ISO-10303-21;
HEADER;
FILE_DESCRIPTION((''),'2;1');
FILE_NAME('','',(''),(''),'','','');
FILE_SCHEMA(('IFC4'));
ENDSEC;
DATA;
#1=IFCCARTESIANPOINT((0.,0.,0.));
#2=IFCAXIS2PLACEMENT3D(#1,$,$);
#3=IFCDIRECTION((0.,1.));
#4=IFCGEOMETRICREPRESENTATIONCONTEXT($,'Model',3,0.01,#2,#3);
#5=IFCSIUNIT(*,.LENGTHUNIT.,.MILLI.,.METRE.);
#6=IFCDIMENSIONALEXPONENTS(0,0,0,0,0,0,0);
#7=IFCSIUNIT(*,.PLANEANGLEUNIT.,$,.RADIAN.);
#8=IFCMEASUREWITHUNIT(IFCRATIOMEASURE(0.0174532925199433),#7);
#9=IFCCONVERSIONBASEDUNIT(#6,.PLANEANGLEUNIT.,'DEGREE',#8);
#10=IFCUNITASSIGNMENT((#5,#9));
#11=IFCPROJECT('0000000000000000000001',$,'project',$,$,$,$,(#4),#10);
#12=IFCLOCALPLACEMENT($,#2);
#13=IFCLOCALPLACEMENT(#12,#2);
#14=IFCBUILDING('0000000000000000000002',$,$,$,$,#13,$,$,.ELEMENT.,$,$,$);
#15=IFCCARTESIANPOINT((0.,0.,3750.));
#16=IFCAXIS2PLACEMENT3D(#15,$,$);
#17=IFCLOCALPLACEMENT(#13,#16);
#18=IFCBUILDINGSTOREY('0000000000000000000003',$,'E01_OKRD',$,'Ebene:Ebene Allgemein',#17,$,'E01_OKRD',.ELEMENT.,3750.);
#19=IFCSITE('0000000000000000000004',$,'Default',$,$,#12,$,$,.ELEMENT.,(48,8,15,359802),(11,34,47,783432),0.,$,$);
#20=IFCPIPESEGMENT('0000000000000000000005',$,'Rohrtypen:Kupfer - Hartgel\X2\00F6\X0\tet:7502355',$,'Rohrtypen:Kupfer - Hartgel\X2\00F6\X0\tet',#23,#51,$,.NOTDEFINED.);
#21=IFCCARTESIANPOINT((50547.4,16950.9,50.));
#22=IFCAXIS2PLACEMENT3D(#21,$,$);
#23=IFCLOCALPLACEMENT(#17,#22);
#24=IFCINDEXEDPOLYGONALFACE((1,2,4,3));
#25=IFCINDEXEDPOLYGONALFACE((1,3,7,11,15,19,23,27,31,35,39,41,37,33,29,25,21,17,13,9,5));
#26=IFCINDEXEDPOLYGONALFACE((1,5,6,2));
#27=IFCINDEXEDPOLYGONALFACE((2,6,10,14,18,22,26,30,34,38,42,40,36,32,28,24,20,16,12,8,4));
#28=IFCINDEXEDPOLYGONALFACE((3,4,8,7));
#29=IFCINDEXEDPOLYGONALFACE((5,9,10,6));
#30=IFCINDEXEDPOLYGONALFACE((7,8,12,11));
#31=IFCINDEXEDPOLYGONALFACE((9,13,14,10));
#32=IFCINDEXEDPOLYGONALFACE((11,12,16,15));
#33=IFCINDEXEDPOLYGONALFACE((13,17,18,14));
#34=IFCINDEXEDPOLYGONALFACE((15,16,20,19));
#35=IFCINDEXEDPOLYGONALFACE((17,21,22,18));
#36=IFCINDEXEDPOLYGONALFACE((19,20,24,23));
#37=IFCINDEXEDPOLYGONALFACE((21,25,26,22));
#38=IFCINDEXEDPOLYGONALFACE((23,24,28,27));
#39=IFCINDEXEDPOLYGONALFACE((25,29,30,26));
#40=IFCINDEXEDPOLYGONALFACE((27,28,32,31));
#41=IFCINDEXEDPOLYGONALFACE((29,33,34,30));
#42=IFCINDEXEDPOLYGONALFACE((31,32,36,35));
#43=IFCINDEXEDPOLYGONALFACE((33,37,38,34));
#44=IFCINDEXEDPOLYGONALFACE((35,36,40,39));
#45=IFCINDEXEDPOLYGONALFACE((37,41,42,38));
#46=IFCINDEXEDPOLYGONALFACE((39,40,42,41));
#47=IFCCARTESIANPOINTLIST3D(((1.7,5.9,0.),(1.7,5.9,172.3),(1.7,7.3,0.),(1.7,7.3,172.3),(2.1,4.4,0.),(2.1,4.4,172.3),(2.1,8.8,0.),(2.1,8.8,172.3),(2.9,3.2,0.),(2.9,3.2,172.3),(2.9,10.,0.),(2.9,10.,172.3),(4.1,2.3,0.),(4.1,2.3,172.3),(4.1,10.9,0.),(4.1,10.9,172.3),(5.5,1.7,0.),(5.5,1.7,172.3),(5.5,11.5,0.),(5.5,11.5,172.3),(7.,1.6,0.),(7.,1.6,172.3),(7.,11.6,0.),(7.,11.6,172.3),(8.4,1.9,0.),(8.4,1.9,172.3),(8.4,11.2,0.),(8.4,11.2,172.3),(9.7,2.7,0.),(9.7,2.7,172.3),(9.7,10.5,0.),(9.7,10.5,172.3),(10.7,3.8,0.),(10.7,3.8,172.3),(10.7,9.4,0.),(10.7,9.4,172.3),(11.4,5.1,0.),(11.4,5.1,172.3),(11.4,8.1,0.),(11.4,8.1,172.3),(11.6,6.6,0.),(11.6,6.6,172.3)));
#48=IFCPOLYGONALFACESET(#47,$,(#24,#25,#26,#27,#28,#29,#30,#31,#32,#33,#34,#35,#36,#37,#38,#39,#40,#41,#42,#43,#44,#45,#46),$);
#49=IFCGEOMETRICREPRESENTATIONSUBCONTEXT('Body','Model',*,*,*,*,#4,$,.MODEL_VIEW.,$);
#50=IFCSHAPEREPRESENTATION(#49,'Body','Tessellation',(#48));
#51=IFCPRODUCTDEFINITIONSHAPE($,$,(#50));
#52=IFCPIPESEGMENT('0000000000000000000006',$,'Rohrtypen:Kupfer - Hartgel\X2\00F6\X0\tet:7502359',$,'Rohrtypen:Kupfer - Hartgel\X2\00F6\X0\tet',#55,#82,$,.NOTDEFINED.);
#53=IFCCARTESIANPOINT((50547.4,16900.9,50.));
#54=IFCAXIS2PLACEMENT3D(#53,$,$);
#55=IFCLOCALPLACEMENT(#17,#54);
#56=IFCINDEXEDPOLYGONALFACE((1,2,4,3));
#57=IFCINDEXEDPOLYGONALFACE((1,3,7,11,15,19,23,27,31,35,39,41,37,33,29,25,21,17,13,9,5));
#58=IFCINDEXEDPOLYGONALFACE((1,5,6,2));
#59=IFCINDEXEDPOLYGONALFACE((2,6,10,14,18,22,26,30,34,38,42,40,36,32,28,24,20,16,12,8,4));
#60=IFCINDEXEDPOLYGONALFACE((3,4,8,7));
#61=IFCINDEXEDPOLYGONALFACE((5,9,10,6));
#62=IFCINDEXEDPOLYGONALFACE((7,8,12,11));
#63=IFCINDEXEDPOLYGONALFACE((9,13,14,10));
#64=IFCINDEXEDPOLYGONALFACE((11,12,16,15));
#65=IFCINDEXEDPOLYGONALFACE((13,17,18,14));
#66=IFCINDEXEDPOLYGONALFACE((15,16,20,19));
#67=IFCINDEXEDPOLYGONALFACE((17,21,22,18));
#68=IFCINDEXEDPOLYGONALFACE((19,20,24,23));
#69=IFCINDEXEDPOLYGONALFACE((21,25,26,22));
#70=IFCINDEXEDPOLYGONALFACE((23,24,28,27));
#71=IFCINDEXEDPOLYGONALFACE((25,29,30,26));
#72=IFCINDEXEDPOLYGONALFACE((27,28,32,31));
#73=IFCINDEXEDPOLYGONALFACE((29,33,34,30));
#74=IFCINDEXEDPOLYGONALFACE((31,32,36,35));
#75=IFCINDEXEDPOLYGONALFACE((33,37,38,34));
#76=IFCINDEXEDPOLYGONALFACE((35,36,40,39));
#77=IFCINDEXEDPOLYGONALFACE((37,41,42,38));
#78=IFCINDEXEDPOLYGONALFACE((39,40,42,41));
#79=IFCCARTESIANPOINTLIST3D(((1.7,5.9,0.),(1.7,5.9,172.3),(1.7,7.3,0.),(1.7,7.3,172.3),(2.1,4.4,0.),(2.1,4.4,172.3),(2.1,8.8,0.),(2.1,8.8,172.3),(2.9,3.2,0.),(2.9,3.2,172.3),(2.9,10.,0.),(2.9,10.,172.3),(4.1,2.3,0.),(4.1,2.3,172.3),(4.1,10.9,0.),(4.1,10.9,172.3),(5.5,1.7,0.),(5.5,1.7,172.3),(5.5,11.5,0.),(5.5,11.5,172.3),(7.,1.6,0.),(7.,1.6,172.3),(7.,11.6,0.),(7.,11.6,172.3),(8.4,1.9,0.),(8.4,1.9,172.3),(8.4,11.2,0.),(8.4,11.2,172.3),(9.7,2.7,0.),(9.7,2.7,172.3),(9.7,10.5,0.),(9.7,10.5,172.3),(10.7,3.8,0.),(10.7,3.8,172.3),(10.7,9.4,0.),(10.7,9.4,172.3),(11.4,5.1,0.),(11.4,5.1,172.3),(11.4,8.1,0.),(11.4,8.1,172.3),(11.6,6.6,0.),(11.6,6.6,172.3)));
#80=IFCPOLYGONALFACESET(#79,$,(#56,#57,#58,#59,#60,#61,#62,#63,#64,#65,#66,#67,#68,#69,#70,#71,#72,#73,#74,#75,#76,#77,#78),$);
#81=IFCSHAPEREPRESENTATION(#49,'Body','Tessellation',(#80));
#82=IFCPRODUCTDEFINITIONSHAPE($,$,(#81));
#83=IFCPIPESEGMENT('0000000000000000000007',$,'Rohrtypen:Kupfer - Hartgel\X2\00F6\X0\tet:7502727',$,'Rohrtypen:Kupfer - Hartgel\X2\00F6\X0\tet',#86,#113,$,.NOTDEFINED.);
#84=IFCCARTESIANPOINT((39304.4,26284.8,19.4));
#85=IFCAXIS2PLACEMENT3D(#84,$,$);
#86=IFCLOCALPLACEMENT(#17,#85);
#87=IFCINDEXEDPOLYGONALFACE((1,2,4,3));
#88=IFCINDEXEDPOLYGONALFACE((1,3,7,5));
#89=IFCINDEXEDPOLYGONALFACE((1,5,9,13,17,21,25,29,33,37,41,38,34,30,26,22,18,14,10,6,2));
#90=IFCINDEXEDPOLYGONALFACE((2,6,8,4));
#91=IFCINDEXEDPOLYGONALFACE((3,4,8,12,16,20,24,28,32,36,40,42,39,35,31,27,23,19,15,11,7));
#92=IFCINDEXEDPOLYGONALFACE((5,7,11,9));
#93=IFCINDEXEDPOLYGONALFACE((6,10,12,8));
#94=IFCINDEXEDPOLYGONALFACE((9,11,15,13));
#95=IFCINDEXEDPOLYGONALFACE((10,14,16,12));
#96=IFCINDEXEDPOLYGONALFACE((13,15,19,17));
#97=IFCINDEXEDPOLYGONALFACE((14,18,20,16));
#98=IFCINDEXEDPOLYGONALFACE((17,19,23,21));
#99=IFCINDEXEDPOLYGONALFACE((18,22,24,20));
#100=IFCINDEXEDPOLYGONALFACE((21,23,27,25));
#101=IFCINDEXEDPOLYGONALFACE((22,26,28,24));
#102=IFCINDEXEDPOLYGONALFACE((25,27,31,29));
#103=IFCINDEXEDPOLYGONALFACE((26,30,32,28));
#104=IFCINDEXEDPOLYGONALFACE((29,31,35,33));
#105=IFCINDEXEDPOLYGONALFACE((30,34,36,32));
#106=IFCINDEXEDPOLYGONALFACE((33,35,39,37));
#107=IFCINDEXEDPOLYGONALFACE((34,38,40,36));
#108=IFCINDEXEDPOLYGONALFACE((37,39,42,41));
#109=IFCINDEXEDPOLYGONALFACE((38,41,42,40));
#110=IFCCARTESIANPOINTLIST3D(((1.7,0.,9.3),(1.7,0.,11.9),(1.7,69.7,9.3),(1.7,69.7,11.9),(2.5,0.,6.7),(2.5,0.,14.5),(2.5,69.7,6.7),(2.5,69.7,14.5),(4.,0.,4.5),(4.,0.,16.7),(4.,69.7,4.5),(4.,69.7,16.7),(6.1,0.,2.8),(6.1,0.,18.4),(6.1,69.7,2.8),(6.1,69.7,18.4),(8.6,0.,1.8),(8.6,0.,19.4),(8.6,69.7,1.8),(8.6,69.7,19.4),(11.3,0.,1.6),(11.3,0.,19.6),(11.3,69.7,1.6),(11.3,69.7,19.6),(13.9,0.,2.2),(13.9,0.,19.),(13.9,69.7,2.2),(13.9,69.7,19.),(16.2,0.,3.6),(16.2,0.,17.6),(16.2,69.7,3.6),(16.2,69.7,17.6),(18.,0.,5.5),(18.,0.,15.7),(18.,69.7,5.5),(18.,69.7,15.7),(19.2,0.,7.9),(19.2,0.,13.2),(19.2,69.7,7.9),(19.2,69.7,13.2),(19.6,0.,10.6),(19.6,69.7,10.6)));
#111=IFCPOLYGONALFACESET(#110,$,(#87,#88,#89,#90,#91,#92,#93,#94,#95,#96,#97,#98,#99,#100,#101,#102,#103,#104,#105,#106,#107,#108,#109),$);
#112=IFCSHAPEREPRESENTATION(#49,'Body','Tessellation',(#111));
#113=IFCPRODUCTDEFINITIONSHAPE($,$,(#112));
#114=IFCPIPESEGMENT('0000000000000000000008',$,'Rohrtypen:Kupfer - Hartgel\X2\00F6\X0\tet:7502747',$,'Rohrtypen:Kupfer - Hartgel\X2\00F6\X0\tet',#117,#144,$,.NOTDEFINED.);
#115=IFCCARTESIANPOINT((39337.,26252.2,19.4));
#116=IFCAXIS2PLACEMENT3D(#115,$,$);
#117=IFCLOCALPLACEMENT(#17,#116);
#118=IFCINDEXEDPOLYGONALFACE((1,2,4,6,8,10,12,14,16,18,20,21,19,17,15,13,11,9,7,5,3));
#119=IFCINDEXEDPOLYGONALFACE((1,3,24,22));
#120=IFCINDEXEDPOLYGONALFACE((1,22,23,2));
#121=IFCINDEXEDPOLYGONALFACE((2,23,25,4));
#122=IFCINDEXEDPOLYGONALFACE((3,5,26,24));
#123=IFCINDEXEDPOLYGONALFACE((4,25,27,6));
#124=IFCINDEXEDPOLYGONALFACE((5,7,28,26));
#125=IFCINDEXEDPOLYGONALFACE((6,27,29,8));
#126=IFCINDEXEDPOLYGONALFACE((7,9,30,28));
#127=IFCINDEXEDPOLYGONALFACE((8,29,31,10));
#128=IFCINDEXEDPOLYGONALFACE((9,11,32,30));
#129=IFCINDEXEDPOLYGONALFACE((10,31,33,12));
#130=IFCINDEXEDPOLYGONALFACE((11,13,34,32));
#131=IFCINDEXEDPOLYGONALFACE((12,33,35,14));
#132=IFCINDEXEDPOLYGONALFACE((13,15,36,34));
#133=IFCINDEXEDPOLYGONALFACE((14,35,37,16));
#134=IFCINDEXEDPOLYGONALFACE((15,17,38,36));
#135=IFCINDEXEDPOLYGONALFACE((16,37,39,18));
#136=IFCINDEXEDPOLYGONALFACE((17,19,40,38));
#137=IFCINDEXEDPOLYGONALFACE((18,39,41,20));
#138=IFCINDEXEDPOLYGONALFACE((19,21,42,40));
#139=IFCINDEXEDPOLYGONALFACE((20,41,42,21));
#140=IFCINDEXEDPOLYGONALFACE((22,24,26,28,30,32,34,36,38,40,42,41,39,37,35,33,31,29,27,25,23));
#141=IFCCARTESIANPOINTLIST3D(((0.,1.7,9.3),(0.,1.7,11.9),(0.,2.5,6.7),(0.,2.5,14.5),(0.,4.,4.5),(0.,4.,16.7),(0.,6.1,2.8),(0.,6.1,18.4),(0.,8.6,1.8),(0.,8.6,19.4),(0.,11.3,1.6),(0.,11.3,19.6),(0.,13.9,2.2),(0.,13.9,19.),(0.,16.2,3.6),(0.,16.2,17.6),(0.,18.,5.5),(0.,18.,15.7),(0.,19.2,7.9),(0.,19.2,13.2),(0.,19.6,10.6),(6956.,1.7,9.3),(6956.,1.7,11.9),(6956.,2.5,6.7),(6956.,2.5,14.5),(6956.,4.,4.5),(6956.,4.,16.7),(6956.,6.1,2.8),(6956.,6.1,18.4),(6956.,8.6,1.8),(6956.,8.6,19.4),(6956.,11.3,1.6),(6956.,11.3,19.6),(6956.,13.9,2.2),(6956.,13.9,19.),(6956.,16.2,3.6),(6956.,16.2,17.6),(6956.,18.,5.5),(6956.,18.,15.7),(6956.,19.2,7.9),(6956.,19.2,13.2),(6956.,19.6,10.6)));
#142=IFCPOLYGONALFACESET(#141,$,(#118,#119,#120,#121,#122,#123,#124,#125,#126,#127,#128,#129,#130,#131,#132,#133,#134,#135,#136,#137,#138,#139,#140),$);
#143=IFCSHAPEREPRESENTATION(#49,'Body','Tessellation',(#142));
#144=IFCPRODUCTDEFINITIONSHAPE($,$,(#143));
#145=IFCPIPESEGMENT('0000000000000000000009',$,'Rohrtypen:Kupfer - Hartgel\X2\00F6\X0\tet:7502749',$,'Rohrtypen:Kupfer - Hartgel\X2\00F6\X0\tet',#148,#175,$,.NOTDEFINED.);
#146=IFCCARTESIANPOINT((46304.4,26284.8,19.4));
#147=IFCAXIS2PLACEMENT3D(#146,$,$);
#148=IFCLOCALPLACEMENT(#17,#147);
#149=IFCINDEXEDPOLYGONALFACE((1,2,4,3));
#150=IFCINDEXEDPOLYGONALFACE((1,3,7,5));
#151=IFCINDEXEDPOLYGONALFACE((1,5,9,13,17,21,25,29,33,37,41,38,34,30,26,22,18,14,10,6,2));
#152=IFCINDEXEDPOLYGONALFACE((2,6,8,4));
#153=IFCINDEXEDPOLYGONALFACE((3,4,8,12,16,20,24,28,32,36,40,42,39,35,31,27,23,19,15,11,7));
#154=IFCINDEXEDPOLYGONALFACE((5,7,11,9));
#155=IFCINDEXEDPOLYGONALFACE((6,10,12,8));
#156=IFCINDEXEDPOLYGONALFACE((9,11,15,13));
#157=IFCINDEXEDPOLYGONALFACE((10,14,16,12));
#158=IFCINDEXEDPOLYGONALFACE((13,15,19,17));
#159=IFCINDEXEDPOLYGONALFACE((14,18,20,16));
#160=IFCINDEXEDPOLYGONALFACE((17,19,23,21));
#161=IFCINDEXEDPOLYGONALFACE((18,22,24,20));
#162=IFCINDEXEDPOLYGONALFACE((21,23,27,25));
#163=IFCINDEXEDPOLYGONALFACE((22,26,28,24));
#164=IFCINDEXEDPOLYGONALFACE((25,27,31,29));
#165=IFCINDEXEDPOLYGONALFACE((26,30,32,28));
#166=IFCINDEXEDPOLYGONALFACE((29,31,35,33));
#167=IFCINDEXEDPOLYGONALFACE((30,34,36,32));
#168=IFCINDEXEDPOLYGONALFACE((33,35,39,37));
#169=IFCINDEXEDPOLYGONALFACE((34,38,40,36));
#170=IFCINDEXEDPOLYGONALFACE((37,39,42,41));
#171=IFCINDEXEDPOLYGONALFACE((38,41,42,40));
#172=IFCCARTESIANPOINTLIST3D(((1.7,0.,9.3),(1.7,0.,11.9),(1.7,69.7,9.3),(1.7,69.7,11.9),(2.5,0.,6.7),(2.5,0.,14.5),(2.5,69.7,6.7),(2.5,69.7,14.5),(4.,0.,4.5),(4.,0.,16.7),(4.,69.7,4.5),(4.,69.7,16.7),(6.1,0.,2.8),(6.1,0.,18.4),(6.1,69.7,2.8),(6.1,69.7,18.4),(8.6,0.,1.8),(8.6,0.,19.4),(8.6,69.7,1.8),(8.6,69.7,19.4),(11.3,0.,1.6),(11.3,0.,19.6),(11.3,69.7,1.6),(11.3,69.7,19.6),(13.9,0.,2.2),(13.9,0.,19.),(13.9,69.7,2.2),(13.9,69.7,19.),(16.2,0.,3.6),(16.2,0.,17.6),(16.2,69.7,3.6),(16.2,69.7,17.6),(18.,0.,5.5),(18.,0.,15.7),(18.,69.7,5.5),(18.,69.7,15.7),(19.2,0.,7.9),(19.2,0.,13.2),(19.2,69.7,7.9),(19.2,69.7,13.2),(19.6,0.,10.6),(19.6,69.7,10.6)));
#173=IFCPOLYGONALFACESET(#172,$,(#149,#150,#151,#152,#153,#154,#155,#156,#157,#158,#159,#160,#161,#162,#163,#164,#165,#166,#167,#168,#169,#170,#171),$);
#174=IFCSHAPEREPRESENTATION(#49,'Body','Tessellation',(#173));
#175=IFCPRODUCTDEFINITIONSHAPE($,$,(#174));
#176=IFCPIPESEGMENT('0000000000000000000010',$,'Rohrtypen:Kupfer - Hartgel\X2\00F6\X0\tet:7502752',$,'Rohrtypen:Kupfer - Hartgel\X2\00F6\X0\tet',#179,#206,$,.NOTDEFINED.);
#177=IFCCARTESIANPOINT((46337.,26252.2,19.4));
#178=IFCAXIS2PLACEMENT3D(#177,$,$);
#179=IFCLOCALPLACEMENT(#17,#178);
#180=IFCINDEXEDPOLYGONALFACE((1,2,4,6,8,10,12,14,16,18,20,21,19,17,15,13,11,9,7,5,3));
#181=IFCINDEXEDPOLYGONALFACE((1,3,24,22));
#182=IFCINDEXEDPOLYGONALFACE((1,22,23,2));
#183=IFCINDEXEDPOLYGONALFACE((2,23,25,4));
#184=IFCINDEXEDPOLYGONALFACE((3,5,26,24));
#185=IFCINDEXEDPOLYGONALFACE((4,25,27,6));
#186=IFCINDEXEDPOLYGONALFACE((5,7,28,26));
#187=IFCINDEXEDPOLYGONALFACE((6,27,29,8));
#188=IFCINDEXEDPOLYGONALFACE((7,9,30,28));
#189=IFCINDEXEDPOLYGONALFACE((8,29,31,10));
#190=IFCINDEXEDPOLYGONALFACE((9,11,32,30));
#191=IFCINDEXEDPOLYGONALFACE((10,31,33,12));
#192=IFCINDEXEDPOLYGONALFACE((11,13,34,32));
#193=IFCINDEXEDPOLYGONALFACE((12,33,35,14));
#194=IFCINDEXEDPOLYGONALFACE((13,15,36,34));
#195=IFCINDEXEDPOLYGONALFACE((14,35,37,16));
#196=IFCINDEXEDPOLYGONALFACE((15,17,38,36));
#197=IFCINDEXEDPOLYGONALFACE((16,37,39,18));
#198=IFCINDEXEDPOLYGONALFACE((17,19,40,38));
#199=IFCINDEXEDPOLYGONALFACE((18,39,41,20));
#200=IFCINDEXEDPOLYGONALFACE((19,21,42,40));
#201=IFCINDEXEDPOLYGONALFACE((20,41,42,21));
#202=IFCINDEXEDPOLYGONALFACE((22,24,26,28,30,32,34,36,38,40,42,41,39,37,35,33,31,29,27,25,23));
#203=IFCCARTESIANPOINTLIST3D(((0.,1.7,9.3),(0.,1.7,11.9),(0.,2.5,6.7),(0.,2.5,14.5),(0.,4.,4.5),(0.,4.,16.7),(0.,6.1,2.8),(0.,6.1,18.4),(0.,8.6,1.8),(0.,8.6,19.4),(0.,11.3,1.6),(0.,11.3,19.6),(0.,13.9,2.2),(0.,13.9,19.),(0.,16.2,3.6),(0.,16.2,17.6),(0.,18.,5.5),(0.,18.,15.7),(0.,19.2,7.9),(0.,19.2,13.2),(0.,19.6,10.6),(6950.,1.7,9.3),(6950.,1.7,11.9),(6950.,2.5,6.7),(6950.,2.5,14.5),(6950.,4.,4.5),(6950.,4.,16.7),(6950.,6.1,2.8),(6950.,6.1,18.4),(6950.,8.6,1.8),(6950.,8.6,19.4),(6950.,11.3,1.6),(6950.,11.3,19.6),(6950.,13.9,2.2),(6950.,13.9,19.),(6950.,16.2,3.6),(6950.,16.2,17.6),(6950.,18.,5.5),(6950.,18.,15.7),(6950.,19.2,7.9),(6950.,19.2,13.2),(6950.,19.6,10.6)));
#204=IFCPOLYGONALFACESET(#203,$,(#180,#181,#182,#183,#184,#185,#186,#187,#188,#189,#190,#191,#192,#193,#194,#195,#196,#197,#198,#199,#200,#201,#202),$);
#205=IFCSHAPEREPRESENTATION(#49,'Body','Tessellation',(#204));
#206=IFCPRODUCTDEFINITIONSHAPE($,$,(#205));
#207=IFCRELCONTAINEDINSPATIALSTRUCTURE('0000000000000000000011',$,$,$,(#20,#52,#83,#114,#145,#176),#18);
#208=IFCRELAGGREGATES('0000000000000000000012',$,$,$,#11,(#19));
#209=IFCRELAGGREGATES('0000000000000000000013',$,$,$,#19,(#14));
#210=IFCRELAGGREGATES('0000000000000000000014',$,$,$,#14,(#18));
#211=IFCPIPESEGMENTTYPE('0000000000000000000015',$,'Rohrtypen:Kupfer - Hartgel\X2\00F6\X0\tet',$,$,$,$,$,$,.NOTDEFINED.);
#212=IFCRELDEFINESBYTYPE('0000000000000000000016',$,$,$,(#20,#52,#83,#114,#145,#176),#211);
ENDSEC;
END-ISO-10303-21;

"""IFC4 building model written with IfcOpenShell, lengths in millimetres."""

from ifc_helpers import new_model, entity, si_unit, converted_unit, direction, frame, origin, origin_2d_with_axis, place, context, subcontext, project, spatial, circle, extrude, type_object, element, save


model = new_model("IFC4")

# Units and contexts
model_context = context("Model", 3, precision=0.01, world=origin(), true_north=direction((0.0, 1.0)))
body_context = subcontext(model_context, "Body", "Model", "MODEL_VIEW")
ifc_project = project(units=[si_unit("LENGTHUNIT", "METRE", prefix="MILLI"), converted_unit("PLANEANGLEUNIT", "DEGREE", entity("IfcRatioMeasure", 0.0174532925199433), si_unit("PLANEANGLEUNIT", "RADIAN"), dimensions=[0, 0, 0, 0, 0, 0, 0])], contexts=[model_context])

# Site, building, storey
site_placement = place(None, origin())
site = spatial("IfcSite", under=ifc_project, at=site_placement, Name="Default", CompositionType="ELEMENT", RefLatitude=(48, 8, 15, 359802), RefLongitude=(11, 34, 47, 783432), RefElevation=0.0)
building_placement = place(site_placement, origin())
building = spatial("IfcBuilding", under=site, at=building_placement, CompositionType="ELEMENT")
storey_placement = place(building_placement, frame((0.0, 0.0, 3750.0)))
storey = spatial("IfcBuildingStorey", under=building, at=storey_placement, Name="E01_OKRD", ObjectType="Ebene:Ebene Allgemein", LongName="E01_OKRD", CompositionType="ELEMENT", Elevation=3750.0)

# Pipe segments
pipe_segment_type = type_object("IfcPipeSegmentType", Name="Rohrtypen:Kupfer - Hartgelötet", PredefinedType="NOTDEFINED")
pipe_segment_1_placement = place(storey_placement, frame((50547.4, 16950.9, 50.0)))
element("IfcPipeSegment", 1, at=pipe_segment_1_placement, inside=storey, type_object=pipe_segment_type, Name="Rohrtypen:Kupfer - Hartgelötet:7502355", ObjectType="Rohrtypen:Kupfer - Hartgelötet", PredefinedType="NOTDEFINED", context=body_context, shape_type="SweptSolid", body=[
    extrude(circle(Radius=5.0, at=origin_2d_with_axis()), frame((6.6, 6.6, 0.0)), (0.0, 0.0, 1.0), 172.3),
])
pipe_segment_2_placement = place(storey_placement, frame((50547.4, 16900.9, 50.0)))
element("IfcPipeSegment", 2, at=pipe_segment_2_placement, inside=storey, type_object=pipe_segment_type, Name="Rohrtypen:Kupfer - Hartgelötet:7502359", ObjectType="Rohrtypen:Kupfer - Hartgelötet", PredefinedType="NOTDEFINED", context=body_context, shape_type="SweptSolid", body=[
    extrude(circle(Radius=5.0, at=origin_2d_with_axis()), frame((6.6, 6.6, 0.0)), (0.0, 0.0, 1.0), 172.3),
])
pipe_segment_3_placement = place(storey_placement, frame((39304.4, 26284.8, 19.4)))
element("IfcPipeSegment", 3, at=pipe_segment_3_placement, inside=storey, type_object=pipe_segment_type, Name="Rohrtypen:Kupfer - Hartgelötet:7502727", ObjectType="Rohrtypen:Kupfer - Hartgelötet", PredefinedType="NOTDEFINED", context=body_context, shape_type="SweptSolid", body=[
    extrude(circle(Radius=9.0, at=origin_2d_with_axis()), frame((10.6, 0.0, 10.6), z_axis=(0.0, 1.0, 0.0), x_axis=(1.0, 0.0, 0.0)), (0.0, 0.0, 1.0), 69.7),
])
pipe_segment_4_placement = place(storey_placement, frame((39337.0, 26252.2, 19.4)))
element("IfcPipeSegment", 4, at=pipe_segment_4_placement, inside=storey, type_object=pipe_segment_type, Name="Rohrtypen:Kupfer - Hartgelötet:7502747", ObjectType="Rohrtypen:Kupfer - Hartgelötet", PredefinedType="NOTDEFINED", context=body_context, shape_type="SweptSolid", body=[
    extrude(circle(Radius=9.0, at=origin_2d_with_axis()), frame((0.0, 10.6, 10.6), z_axis=(1.0, 0.0, 0.0), x_axis=(0.0, 1.0, 0.0)), (0.0, 0.0, 1.0), 6956.0),
])
pipe_segment_5_placement = place(storey_placement, frame((46304.4, 26284.8, 19.4)))
element("IfcPipeSegment", 5, at=pipe_segment_5_placement, inside=storey, type_object=pipe_segment_type, Name="Rohrtypen:Kupfer - Hartgelötet:7502749", ObjectType="Rohrtypen:Kupfer - Hartgelötet", PredefinedType="NOTDEFINED", context=body_context, shape_type="SweptSolid", body=[
    extrude(circle(Radius=9.0, at=origin_2d_with_axis()), frame((10.6, 0.0, 10.6), z_axis=(0.0, 1.0, 0.0), x_axis=(1.0, 0.0, 0.0)), (0.0, 0.0, 1.0), 69.7),
])
pipe_segment_6_placement = place(storey_placement, frame((46337.0, 26252.2, 19.4)))
element("IfcPipeSegment", 6, at=pipe_segment_6_placement, inside=storey, type_object=pipe_segment_type, Name="Rohrtypen:Kupfer - Hartgelötet:7502752", ObjectType="Rohrtypen:Kupfer - Hartgelötet", PredefinedType="NOTDEFINED", context=body_context, shape_type="SweptSolid", body=[
    extrude(circle(Radius=9.0, at=origin_2d_with_axis()), frame((0.0, 10.6, 10.6), z_axis=(1.0, 0.0, 0.0), x_axis=(0.0, 1.0, 0.0)), (0.0, 0.0, 1.0), 6950.0),
])

save(model, "model.ifc")
